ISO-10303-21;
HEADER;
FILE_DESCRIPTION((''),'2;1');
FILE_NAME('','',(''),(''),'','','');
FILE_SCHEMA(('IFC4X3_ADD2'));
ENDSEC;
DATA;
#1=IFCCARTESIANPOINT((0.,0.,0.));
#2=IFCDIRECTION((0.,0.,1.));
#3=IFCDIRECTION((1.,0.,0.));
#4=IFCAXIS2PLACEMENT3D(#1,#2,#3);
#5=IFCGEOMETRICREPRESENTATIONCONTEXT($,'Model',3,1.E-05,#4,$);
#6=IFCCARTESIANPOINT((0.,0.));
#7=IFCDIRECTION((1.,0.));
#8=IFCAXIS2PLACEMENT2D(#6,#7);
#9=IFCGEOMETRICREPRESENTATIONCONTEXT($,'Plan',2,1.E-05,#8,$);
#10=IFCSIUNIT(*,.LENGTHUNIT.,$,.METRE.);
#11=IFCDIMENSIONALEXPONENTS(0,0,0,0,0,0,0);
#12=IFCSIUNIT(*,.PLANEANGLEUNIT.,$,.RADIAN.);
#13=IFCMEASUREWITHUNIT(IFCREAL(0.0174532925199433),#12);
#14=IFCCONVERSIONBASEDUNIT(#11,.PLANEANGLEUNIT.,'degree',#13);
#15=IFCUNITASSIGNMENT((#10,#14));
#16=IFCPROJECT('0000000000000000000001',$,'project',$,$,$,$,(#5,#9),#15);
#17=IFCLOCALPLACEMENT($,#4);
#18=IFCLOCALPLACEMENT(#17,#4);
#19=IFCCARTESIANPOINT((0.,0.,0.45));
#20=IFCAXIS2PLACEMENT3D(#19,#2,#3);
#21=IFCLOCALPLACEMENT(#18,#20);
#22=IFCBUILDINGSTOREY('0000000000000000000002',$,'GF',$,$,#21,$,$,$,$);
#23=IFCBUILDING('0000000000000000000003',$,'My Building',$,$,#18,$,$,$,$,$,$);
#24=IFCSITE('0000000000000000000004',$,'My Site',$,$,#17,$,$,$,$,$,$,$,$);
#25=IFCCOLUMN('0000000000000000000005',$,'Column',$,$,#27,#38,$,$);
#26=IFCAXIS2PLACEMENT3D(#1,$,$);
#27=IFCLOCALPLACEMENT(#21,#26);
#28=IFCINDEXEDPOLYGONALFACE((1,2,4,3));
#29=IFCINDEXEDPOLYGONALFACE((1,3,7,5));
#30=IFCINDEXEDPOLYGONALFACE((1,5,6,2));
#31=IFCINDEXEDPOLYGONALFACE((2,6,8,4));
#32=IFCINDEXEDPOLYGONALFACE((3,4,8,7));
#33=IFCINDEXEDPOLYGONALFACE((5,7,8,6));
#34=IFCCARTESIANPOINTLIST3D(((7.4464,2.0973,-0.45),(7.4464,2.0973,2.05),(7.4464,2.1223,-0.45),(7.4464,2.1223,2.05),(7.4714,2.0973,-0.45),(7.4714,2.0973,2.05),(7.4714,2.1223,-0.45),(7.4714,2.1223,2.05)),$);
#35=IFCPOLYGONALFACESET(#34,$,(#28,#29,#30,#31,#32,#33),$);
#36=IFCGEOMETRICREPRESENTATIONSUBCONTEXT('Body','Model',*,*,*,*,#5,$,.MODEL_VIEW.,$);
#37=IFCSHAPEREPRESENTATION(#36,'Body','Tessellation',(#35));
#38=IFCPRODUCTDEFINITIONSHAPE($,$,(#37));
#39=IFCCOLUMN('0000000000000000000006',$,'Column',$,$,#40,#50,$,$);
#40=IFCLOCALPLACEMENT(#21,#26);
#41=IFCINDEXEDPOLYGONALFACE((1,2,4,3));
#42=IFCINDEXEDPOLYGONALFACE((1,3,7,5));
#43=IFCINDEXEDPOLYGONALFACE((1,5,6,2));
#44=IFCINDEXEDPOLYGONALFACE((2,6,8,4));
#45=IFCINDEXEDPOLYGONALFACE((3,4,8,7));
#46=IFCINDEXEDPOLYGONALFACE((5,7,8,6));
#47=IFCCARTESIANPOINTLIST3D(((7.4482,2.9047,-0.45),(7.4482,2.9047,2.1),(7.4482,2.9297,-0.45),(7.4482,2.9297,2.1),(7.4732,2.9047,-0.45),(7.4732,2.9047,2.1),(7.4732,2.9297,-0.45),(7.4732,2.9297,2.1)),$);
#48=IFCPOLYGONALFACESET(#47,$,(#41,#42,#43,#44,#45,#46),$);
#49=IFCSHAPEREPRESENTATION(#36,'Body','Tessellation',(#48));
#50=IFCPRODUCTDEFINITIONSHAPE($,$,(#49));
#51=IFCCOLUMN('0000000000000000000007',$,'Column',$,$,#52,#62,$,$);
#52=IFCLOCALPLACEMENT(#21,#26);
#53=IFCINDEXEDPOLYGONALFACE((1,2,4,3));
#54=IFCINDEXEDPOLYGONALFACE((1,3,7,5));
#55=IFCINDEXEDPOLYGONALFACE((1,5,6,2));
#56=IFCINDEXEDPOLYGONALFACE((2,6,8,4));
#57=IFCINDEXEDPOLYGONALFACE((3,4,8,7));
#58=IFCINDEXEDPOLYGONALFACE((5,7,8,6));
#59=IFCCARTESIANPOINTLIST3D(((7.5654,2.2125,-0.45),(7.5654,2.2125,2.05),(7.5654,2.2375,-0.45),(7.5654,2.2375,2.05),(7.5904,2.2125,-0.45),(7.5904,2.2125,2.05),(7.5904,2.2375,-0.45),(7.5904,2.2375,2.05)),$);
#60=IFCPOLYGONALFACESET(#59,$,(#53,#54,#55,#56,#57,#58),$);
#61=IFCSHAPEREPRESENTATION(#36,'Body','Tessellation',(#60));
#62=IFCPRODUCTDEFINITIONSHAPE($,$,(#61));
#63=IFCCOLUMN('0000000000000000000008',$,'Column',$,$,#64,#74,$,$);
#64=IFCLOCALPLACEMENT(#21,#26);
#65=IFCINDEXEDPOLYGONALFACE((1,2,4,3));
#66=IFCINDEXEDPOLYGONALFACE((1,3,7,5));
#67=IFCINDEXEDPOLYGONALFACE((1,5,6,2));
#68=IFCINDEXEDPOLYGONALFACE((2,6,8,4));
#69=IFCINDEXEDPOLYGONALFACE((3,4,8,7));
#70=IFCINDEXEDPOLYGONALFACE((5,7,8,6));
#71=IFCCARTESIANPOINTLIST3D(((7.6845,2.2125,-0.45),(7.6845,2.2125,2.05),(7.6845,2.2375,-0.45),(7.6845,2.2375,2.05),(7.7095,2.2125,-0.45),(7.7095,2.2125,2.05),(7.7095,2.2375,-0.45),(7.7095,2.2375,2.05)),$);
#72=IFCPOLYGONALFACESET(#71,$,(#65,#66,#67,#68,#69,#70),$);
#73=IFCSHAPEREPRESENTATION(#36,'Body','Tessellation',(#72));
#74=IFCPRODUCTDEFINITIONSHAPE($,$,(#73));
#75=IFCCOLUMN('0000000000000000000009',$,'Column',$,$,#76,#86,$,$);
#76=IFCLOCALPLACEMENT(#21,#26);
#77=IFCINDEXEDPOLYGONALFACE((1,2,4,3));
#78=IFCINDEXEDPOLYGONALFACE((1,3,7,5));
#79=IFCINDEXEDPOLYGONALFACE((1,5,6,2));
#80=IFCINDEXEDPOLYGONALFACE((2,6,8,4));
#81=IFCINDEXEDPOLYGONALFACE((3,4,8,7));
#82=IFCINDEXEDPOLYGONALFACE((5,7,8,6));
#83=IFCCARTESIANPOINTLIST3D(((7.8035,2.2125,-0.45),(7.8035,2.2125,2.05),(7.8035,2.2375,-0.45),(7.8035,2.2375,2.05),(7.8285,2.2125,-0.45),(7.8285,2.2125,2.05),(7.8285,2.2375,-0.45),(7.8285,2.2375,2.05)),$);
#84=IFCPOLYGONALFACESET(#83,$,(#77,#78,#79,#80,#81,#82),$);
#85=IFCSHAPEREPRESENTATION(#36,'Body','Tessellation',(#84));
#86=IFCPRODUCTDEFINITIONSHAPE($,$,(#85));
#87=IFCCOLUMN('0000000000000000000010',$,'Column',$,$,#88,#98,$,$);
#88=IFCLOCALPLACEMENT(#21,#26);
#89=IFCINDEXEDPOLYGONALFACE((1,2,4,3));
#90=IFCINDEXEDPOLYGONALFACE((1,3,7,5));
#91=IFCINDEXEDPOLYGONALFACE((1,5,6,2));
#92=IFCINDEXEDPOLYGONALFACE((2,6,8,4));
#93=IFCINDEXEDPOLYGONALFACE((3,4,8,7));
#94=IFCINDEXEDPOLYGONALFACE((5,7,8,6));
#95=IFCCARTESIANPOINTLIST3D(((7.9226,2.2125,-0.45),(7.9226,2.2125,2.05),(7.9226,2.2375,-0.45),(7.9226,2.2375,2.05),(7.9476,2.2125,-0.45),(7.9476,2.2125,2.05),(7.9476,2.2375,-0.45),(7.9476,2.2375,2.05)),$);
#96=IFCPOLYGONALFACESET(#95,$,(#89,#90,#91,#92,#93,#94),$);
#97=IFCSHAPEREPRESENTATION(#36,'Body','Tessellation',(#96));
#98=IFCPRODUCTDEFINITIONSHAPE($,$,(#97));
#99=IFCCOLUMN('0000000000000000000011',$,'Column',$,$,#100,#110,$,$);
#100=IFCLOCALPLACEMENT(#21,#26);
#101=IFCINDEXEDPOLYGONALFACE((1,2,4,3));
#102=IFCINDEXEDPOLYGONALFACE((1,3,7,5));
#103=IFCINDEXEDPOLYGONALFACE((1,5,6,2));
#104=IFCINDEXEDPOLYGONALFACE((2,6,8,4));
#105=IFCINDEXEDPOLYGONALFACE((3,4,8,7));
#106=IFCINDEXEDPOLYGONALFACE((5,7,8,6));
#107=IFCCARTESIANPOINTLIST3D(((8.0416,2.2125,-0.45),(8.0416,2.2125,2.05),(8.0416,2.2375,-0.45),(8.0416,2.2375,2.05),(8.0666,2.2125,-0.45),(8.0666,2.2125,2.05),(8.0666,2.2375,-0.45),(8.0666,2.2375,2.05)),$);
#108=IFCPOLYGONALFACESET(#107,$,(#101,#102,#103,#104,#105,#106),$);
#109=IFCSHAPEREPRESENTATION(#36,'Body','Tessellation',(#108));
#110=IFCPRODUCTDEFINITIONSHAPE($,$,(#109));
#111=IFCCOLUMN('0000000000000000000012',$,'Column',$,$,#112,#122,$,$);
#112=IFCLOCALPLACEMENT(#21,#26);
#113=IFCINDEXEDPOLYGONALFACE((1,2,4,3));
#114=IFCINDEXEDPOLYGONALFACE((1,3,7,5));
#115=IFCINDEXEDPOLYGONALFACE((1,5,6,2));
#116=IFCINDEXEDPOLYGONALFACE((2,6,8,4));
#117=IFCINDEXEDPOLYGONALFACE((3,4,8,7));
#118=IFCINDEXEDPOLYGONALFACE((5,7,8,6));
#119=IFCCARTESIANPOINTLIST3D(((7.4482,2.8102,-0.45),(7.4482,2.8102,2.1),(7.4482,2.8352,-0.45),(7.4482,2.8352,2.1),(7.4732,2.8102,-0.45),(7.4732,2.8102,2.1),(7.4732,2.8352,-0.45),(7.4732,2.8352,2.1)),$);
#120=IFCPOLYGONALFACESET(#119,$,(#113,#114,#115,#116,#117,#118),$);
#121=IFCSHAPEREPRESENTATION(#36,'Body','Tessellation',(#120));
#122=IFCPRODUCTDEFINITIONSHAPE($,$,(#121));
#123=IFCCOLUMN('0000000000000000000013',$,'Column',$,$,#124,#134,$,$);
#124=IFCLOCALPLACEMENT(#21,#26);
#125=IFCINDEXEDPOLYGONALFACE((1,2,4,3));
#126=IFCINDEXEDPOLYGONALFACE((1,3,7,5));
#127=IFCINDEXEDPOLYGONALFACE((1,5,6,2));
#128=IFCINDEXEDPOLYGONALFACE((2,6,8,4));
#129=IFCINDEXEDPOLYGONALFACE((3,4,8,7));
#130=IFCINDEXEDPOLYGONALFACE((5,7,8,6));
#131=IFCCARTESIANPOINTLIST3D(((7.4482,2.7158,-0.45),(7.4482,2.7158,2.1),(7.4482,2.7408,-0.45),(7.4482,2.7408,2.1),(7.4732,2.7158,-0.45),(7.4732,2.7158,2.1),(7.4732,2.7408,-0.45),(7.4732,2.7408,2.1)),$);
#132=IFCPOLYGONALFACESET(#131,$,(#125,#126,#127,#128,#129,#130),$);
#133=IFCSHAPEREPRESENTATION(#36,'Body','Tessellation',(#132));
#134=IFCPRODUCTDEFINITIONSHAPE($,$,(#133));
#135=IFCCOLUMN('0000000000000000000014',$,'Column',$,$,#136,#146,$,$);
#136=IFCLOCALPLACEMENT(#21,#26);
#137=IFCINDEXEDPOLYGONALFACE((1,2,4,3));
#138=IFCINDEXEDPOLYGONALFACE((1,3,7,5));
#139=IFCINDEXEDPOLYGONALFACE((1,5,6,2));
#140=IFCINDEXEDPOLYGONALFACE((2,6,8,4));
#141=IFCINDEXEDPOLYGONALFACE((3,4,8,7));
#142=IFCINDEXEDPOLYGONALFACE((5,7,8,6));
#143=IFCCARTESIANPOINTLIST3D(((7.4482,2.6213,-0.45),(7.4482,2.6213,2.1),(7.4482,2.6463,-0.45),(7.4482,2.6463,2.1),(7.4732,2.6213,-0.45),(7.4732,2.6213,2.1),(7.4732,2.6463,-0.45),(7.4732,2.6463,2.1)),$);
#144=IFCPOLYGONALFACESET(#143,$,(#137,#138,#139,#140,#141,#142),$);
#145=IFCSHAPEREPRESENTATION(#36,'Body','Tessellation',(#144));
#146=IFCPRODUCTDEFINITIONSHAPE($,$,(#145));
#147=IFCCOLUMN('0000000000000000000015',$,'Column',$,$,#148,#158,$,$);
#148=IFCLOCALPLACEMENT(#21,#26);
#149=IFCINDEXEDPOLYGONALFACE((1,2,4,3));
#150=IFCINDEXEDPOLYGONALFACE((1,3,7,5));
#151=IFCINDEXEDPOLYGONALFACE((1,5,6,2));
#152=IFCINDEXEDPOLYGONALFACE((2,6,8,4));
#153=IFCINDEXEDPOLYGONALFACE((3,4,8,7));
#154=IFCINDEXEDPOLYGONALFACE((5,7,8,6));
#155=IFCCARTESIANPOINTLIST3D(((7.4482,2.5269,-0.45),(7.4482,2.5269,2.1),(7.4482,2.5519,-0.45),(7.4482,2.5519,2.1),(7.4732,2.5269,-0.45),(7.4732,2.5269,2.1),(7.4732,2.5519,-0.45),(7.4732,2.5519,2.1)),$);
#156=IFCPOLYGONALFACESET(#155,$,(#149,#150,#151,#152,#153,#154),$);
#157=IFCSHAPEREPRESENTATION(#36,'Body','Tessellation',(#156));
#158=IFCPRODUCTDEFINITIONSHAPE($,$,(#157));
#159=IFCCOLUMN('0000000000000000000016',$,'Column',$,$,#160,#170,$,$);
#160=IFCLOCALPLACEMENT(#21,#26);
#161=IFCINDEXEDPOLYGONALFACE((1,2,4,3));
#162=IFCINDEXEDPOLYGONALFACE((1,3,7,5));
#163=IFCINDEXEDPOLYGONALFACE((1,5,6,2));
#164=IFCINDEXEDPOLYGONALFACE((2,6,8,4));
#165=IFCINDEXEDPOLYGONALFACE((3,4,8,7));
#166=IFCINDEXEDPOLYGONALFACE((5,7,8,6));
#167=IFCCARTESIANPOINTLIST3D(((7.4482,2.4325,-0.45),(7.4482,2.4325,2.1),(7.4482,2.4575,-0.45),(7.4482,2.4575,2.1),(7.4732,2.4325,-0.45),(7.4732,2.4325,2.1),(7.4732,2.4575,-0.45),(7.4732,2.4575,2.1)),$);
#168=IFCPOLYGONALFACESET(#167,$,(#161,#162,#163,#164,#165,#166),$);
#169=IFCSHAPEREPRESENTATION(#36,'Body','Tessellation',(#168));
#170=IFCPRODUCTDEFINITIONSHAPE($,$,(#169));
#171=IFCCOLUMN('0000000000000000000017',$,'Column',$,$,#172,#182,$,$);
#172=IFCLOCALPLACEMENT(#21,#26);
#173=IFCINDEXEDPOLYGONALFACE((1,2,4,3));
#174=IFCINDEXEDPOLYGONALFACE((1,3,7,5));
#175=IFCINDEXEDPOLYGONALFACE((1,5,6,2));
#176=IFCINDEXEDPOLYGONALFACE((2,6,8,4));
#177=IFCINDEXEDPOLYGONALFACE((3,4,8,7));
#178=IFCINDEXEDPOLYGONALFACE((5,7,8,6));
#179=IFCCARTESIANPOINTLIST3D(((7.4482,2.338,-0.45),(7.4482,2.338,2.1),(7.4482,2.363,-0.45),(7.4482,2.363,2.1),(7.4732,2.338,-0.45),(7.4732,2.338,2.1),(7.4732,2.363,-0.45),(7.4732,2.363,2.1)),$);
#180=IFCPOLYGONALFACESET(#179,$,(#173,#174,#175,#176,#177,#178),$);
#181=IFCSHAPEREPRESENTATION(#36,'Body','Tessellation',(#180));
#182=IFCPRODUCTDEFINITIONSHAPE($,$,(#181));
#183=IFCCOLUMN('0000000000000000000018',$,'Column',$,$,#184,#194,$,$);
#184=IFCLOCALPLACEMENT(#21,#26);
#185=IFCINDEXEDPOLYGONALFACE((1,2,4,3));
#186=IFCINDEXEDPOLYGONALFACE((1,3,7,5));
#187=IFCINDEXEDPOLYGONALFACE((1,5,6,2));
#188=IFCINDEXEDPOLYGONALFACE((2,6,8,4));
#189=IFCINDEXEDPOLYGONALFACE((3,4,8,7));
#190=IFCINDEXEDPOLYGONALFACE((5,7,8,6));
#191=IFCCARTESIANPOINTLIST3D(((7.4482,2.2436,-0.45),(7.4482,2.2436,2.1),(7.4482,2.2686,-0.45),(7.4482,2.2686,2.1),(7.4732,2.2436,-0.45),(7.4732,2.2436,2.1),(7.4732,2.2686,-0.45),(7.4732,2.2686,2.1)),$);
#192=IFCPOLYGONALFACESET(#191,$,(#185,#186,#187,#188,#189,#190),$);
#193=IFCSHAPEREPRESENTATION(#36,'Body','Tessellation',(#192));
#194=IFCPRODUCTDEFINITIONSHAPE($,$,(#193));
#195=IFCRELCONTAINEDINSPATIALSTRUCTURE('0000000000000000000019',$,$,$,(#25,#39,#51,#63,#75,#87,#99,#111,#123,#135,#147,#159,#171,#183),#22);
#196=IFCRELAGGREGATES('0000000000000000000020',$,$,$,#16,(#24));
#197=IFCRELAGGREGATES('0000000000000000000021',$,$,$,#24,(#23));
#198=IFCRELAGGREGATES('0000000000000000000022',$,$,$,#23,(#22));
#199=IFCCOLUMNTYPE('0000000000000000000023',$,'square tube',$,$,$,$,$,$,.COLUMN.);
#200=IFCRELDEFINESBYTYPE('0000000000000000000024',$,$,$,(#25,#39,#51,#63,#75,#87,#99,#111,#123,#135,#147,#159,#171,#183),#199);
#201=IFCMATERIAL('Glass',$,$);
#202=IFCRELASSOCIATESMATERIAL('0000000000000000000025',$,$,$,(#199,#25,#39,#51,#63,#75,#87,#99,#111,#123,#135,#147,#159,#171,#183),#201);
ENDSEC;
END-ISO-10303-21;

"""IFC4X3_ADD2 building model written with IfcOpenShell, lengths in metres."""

from ifc_helpers import new_model, entity, si_unit, converted_unit, frame, origin_with_axes, origin_2d_with_axis, place, context, subcontext, project, spatial, rectangle, extrude, material, material_profile, profile_set, profile_usage, type_object, element, save


model = new_model("IFC4X3_ADD2")

# Units and contexts
model_context = context("Model", 3, precision=1e-05, world=origin_with_axes())
plan_context = context("Plan", 2, precision=1e-05, world=origin_2d_with_axis())
body_context_1 = subcontext(model_context, "Body", "Model", "MODEL_VIEW")
ifc_project = project(units=[si_unit("LENGTHUNIT", "METRE"), converted_unit("PLANEANGLEUNIT", "degree", entity("IfcReal", 0.0174532925199433), si_unit("PLANEANGLEUNIT", "RADIAN"), dimensions=[0, 0, 0, 0, 0, 0, 0])], contexts=[model_context, plan_context])

# Site, building, storey
site_placement = place(None, origin_with_axes())
site = spatial("IfcSite", under=ifc_project, at=site_placement, Name="My Site")
building_placement = place(site_placement, origin_with_axes())
building = spatial("IfcBuilding", under=site, at=building_placement, Name="My Building")
storey_placement = place(building_placement, frame((0.0, 0.0, 0.45), z_axis=(0.0, 0.0, 1.0), x_axis=(1.0, 0.0, 0.0)))
storey = spatial("IfcBuildingStorey", under=building, at=storey_placement, Name="GF")

# Columns
ifc_material_1 = material(Name="Glass")
ifc_material_profile = material_profile(ifc_material_1, rectangle(XDim=0.025, YDim=0.025))
ifc_profile_set = profile_set([ifc_material_profile])
ifc_profile_usage_1 = profile_usage(ifc_profile_set, cardinal=5)
column_type = type_object("IfcColumnType", Name="square tube", PredefinedType="COLUMN", material=ifc_profile_set)
column_1_placement = place(storey_placement, frame((7.4589, 2.1098, -0.45), z_axis=(0.0, 0.0, 1.0), x_axis=(1.0, 0.0, 0.0)))
element("IfcColumn", 1, at=column_1_placement, inside=storey, type_object=column_type, material=ifc_profile_usage_1, Name="Column", context=body_context_1, shape_type="SweptSolid", body=[
    extrude(rectangle(XDim=0.025, YDim=0.025), origin_with_axes(), (0.0, 0.0, 1.0), 2.5),
])
ifc_profile_usage_2 = profile_usage(ifc_profile_set, cardinal=5)
column_2_placement = place(storey_placement, frame((7.4607, 2.9172, -0.45), z_axis=(0.0, 0.0, 1.0), x_axis=(0.0, -1.0, 0.0)))
element("IfcColumn", 2, at=column_2_placement, inside=storey, type_object=column_type, material=ifc_profile_usage_2, Name="Column", context=body_context_1, shape_type="SweptSolid", body=[
    extrude(rectangle(XDim=0.025, YDim=0.025), origin_with_axes(), (0.0, 0.0, 1.0), 2.55),
])
ifc_profile_usage_3 = profile_usage(ifc_profile_set, cardinal=5)
column_3_placement = place(storey_placement, frame((7.5779, 2.225, -0.45), z_axis=(0.0, 0.0, 1.0), x_axis=(1.0, 0.0, 0.0)))
element("IfcColumn", 3, at=column_3_placement, inside=storey, type_object=column_type, material=ifc_profile_usage_3, Name="Column", context=body_context_1, shape_type="SweptSolid", body=[
    extrude(rectangle(XDim=0.025, YDim=0.025), origin_with_axes(), (0.0, 0.0, 1.0), 2.5),
])
ifc_profile_usage_4 = profile_usage(ifc_profile_set, cardinal=5)
column_4_placement = place(storey_placement, frame((7.697, 2.225, -0.45), z_axis=(0.0, 0.0, 1.0), x_axis=(1.0, 0.0, 0.0)))
element("IfcColumn", 4, at=column_4_placement, inside=storey, type_object=column_type, material=ifc_profile_usage_4, Name="Column", context=body_context_1, shape_type="SweptSolid", body=[
    extrude(rectangle(XDim=0.025, YDim=0.025), origin_with_axes(), (0.0, 0.0, 1.0), 2.5),
])
ifc_profile_usage_5 = profile_usage(ifc_profile_set, cardinal=5)
column_5_placement = place(storey_placement, frame((7.816, 2.225, -0.45), z_axis=(0.0, 0.0, 1.0), x_axis=(1.0, 0.0, 0.0)))
element("IfcColumn", 5, at=column_5_placement, inside=storey, type_object=column_type, material=ifc_profile_usage_5, Name="Column", context=body_context_1, shape_type="SweptSolid", body=[
    extrude(rectangle(XDim=0.025, YDim=0.025), origin_with_axes(), (0.0, 0.0, 1.0), 2.5),
])
ifc_profile_usage_6 = profile_usage(ifc_profile_set, cardinal=5)
column_6_placement = place(storey_placement, frame((7.9351, 2.225, -0.45), z_axis=(0.0, 0.0, 1.0), x_axis=(1.0, 0.0, 0.0)))
element("IfcColumn", 6, at=column_6_placement, inside=storey, type_object=column_type, material=ifc_profile_usage_6, Name="Column", context=body_context_1, shape_type="SweptSolid", body=[
    extrude(rectangle(XDim=0.025, YDim=0.025), origin_with_axes(), (0.0, 0.0, 1.0), 2.5),
])
ifc_profile_usage_7 = profile_usage(ifc_profile_set, cardinal=5)
column_7_placement = place(storey_placement, frame((8.0541, 2.225, -0.45), z_axis=(0.0, 0.0, 1.0), x_axis=(1.0, 0.0, 0.0)))
element("IfcColumn", 7, at=column_7_placement, inside=storey, type_object=column_type, material=ifc_profile_usage_7, Name="Column", context=body_context_1, shape_type="SweptSolid", body=[
    extrude(rectangle(XDim=0.025, YDim=0.025), origin_with_axes(), (0.0, 0.0, 1.0), 2.5),
])
ifc_profile_usage_8 = profile_usage(ifc_profile_set, cardinal=5)
column_8_placement = place(storey_placement, frame((7.4607, 2.8227, -0.45), z_axis=(0.0, 0.0, 1.0), x_axis=(0.0, -1.0, 0.0)))
element("IfcColumn", 8, at=column_8_placement, inside=storey, type_object=column_type, material=ifc_profile_usage_8, Name="Column", context=body_context_1, shape_type="SweptSolid", body=[
    extrude(rectangle(XDim=0.025, YDim=0.025), origin_with_axes(), (0.0, 0.0, 1.0), 2.55),
])
ifc_profile_usage_9 = profile_usage(ifc_profile_set, cardinal=5)
column_9_placement = place(storey_placement, frame((7.4607, 2.7283, -0.45), z_axis=(0.0, 0.0, 1.0), x_axis=(0.0, -1.0, 0.0)))
element("IfcColumn", 9, at=column_9_placement, inside=storey, type_object=column_type, material=ifc_profile_usage_9, Name="Column", context=body_context_1, shape_type="SweptSolid", body=[
    extrude(rectangle(XDim=0.025, YDim=0.025), origin_with_axes(), (0.0, 0.0, 1.0), 2.55),
])
ifc_profile_usage_10 = profile_usage(ifc_profile_set, cardinal=5)
column_10_placement = place(storey_placement, frame((7.4607, 2.6338, -0.45), z_axis=(0.0, 0.0, 1.0), x_axis=(0.0, -1.0, 0.0)))
element("IfcColumn", 10, at=column_10_placement, inside=storey, type_object=column_type, material=ifc_profile_usage_10, Name="Column", context=body_context_1, shape_type="SweptSolid", body=[
    extrude(rectangle(XDim=0.025, YDim=0.025), origin_with_axes(), (0.0, 0.0, 1.0), 2.55),
])
ifc_profile_usage_11 = profile_usage(ifc_profile_set, cardinal=5)
column_11_placement = place(storey_placement, frame((7.4607, 2.5394, -0.45), z_axis=(0.0, 0.0, 1.0), x_axis=(0.0, -1.0, 0.0)))
element("IfcColumn", 11, at=column_11_placement, inside=storey, type_object=column_type, material=ifc_profile_usage_11, Name="Column", context=body_context_1, shape_type="SweptSolid", body=[
    extrude(rectangle(XDim=0.025, YDim=0.025), origin_with_axes(), (0.0, 0.0, 1.0), 2.55),
])
ifc_profile_usage_12 = profile_usage(ifc_profile_set, cardinal=5)
column_12_placement = place(storey_placement, frame((7.4607, 2.445, -0.45), z_axis=(0.0, 0.0, 1.0), x_axis=(0.0, -1.0, 0.0)))
element("IfcColumn", 12, at=column_12_placement, inside=storey, type_object=column_type, material=ifc_profile_usage_12, Name="Column", context=body_context_1, shape_type="SweptSolid", body=[
    extrude(rectangle(XDim=0.025, YDim=0.025), origin_with_axes(), (0.0, 0.0, 1.0), 2.55),
])
ifc_profile_usage_13 = profile_usage(ifc_profile_set, cardinal=5)
column_13_placement = place(storey_placement, frame((7.4607, 2.3505, -0.45), z_axis=(0.0, 0.0, 1.0), x_axis=(0.0, -1.0, 0.0)))
element("IfcColumn", 13, at=column_13_placement, inside=storey, type_object=column_type, material=ifc_profile_usage_13, Name="Column", context=body_context_1, shape_type="SweptSolid", body=[
    extrude(rectangle(XDim=0.025, YDim=0.025), origin_with_axes(), (0.0, 0.0, 1.0), 2.55),
])
ifc_profile_usage_14 = profile_usage(ifc_profile_set, cardinal=5)
column_14_placement = place(storey_placement, frame((7.4607, 2.2561, -0.45), z_axis=(0.0, 0.0, 1.0), x_axis=(0.0, -1.0, 0.0)))
element("IfcColumn", 14, at=column_14_placement, inside=storey, type_object=column_type, material=ifc_profile_usage_14, Name="Column", context=body_context_1, shape_type="SweptSolid", body=[
    extrude(rectangle(XDim=0.025, YDim=0.025), origin_with_axes(), (0.0, 0.0, 1.0), 2.55),
])

save(model, "model.ifc")
